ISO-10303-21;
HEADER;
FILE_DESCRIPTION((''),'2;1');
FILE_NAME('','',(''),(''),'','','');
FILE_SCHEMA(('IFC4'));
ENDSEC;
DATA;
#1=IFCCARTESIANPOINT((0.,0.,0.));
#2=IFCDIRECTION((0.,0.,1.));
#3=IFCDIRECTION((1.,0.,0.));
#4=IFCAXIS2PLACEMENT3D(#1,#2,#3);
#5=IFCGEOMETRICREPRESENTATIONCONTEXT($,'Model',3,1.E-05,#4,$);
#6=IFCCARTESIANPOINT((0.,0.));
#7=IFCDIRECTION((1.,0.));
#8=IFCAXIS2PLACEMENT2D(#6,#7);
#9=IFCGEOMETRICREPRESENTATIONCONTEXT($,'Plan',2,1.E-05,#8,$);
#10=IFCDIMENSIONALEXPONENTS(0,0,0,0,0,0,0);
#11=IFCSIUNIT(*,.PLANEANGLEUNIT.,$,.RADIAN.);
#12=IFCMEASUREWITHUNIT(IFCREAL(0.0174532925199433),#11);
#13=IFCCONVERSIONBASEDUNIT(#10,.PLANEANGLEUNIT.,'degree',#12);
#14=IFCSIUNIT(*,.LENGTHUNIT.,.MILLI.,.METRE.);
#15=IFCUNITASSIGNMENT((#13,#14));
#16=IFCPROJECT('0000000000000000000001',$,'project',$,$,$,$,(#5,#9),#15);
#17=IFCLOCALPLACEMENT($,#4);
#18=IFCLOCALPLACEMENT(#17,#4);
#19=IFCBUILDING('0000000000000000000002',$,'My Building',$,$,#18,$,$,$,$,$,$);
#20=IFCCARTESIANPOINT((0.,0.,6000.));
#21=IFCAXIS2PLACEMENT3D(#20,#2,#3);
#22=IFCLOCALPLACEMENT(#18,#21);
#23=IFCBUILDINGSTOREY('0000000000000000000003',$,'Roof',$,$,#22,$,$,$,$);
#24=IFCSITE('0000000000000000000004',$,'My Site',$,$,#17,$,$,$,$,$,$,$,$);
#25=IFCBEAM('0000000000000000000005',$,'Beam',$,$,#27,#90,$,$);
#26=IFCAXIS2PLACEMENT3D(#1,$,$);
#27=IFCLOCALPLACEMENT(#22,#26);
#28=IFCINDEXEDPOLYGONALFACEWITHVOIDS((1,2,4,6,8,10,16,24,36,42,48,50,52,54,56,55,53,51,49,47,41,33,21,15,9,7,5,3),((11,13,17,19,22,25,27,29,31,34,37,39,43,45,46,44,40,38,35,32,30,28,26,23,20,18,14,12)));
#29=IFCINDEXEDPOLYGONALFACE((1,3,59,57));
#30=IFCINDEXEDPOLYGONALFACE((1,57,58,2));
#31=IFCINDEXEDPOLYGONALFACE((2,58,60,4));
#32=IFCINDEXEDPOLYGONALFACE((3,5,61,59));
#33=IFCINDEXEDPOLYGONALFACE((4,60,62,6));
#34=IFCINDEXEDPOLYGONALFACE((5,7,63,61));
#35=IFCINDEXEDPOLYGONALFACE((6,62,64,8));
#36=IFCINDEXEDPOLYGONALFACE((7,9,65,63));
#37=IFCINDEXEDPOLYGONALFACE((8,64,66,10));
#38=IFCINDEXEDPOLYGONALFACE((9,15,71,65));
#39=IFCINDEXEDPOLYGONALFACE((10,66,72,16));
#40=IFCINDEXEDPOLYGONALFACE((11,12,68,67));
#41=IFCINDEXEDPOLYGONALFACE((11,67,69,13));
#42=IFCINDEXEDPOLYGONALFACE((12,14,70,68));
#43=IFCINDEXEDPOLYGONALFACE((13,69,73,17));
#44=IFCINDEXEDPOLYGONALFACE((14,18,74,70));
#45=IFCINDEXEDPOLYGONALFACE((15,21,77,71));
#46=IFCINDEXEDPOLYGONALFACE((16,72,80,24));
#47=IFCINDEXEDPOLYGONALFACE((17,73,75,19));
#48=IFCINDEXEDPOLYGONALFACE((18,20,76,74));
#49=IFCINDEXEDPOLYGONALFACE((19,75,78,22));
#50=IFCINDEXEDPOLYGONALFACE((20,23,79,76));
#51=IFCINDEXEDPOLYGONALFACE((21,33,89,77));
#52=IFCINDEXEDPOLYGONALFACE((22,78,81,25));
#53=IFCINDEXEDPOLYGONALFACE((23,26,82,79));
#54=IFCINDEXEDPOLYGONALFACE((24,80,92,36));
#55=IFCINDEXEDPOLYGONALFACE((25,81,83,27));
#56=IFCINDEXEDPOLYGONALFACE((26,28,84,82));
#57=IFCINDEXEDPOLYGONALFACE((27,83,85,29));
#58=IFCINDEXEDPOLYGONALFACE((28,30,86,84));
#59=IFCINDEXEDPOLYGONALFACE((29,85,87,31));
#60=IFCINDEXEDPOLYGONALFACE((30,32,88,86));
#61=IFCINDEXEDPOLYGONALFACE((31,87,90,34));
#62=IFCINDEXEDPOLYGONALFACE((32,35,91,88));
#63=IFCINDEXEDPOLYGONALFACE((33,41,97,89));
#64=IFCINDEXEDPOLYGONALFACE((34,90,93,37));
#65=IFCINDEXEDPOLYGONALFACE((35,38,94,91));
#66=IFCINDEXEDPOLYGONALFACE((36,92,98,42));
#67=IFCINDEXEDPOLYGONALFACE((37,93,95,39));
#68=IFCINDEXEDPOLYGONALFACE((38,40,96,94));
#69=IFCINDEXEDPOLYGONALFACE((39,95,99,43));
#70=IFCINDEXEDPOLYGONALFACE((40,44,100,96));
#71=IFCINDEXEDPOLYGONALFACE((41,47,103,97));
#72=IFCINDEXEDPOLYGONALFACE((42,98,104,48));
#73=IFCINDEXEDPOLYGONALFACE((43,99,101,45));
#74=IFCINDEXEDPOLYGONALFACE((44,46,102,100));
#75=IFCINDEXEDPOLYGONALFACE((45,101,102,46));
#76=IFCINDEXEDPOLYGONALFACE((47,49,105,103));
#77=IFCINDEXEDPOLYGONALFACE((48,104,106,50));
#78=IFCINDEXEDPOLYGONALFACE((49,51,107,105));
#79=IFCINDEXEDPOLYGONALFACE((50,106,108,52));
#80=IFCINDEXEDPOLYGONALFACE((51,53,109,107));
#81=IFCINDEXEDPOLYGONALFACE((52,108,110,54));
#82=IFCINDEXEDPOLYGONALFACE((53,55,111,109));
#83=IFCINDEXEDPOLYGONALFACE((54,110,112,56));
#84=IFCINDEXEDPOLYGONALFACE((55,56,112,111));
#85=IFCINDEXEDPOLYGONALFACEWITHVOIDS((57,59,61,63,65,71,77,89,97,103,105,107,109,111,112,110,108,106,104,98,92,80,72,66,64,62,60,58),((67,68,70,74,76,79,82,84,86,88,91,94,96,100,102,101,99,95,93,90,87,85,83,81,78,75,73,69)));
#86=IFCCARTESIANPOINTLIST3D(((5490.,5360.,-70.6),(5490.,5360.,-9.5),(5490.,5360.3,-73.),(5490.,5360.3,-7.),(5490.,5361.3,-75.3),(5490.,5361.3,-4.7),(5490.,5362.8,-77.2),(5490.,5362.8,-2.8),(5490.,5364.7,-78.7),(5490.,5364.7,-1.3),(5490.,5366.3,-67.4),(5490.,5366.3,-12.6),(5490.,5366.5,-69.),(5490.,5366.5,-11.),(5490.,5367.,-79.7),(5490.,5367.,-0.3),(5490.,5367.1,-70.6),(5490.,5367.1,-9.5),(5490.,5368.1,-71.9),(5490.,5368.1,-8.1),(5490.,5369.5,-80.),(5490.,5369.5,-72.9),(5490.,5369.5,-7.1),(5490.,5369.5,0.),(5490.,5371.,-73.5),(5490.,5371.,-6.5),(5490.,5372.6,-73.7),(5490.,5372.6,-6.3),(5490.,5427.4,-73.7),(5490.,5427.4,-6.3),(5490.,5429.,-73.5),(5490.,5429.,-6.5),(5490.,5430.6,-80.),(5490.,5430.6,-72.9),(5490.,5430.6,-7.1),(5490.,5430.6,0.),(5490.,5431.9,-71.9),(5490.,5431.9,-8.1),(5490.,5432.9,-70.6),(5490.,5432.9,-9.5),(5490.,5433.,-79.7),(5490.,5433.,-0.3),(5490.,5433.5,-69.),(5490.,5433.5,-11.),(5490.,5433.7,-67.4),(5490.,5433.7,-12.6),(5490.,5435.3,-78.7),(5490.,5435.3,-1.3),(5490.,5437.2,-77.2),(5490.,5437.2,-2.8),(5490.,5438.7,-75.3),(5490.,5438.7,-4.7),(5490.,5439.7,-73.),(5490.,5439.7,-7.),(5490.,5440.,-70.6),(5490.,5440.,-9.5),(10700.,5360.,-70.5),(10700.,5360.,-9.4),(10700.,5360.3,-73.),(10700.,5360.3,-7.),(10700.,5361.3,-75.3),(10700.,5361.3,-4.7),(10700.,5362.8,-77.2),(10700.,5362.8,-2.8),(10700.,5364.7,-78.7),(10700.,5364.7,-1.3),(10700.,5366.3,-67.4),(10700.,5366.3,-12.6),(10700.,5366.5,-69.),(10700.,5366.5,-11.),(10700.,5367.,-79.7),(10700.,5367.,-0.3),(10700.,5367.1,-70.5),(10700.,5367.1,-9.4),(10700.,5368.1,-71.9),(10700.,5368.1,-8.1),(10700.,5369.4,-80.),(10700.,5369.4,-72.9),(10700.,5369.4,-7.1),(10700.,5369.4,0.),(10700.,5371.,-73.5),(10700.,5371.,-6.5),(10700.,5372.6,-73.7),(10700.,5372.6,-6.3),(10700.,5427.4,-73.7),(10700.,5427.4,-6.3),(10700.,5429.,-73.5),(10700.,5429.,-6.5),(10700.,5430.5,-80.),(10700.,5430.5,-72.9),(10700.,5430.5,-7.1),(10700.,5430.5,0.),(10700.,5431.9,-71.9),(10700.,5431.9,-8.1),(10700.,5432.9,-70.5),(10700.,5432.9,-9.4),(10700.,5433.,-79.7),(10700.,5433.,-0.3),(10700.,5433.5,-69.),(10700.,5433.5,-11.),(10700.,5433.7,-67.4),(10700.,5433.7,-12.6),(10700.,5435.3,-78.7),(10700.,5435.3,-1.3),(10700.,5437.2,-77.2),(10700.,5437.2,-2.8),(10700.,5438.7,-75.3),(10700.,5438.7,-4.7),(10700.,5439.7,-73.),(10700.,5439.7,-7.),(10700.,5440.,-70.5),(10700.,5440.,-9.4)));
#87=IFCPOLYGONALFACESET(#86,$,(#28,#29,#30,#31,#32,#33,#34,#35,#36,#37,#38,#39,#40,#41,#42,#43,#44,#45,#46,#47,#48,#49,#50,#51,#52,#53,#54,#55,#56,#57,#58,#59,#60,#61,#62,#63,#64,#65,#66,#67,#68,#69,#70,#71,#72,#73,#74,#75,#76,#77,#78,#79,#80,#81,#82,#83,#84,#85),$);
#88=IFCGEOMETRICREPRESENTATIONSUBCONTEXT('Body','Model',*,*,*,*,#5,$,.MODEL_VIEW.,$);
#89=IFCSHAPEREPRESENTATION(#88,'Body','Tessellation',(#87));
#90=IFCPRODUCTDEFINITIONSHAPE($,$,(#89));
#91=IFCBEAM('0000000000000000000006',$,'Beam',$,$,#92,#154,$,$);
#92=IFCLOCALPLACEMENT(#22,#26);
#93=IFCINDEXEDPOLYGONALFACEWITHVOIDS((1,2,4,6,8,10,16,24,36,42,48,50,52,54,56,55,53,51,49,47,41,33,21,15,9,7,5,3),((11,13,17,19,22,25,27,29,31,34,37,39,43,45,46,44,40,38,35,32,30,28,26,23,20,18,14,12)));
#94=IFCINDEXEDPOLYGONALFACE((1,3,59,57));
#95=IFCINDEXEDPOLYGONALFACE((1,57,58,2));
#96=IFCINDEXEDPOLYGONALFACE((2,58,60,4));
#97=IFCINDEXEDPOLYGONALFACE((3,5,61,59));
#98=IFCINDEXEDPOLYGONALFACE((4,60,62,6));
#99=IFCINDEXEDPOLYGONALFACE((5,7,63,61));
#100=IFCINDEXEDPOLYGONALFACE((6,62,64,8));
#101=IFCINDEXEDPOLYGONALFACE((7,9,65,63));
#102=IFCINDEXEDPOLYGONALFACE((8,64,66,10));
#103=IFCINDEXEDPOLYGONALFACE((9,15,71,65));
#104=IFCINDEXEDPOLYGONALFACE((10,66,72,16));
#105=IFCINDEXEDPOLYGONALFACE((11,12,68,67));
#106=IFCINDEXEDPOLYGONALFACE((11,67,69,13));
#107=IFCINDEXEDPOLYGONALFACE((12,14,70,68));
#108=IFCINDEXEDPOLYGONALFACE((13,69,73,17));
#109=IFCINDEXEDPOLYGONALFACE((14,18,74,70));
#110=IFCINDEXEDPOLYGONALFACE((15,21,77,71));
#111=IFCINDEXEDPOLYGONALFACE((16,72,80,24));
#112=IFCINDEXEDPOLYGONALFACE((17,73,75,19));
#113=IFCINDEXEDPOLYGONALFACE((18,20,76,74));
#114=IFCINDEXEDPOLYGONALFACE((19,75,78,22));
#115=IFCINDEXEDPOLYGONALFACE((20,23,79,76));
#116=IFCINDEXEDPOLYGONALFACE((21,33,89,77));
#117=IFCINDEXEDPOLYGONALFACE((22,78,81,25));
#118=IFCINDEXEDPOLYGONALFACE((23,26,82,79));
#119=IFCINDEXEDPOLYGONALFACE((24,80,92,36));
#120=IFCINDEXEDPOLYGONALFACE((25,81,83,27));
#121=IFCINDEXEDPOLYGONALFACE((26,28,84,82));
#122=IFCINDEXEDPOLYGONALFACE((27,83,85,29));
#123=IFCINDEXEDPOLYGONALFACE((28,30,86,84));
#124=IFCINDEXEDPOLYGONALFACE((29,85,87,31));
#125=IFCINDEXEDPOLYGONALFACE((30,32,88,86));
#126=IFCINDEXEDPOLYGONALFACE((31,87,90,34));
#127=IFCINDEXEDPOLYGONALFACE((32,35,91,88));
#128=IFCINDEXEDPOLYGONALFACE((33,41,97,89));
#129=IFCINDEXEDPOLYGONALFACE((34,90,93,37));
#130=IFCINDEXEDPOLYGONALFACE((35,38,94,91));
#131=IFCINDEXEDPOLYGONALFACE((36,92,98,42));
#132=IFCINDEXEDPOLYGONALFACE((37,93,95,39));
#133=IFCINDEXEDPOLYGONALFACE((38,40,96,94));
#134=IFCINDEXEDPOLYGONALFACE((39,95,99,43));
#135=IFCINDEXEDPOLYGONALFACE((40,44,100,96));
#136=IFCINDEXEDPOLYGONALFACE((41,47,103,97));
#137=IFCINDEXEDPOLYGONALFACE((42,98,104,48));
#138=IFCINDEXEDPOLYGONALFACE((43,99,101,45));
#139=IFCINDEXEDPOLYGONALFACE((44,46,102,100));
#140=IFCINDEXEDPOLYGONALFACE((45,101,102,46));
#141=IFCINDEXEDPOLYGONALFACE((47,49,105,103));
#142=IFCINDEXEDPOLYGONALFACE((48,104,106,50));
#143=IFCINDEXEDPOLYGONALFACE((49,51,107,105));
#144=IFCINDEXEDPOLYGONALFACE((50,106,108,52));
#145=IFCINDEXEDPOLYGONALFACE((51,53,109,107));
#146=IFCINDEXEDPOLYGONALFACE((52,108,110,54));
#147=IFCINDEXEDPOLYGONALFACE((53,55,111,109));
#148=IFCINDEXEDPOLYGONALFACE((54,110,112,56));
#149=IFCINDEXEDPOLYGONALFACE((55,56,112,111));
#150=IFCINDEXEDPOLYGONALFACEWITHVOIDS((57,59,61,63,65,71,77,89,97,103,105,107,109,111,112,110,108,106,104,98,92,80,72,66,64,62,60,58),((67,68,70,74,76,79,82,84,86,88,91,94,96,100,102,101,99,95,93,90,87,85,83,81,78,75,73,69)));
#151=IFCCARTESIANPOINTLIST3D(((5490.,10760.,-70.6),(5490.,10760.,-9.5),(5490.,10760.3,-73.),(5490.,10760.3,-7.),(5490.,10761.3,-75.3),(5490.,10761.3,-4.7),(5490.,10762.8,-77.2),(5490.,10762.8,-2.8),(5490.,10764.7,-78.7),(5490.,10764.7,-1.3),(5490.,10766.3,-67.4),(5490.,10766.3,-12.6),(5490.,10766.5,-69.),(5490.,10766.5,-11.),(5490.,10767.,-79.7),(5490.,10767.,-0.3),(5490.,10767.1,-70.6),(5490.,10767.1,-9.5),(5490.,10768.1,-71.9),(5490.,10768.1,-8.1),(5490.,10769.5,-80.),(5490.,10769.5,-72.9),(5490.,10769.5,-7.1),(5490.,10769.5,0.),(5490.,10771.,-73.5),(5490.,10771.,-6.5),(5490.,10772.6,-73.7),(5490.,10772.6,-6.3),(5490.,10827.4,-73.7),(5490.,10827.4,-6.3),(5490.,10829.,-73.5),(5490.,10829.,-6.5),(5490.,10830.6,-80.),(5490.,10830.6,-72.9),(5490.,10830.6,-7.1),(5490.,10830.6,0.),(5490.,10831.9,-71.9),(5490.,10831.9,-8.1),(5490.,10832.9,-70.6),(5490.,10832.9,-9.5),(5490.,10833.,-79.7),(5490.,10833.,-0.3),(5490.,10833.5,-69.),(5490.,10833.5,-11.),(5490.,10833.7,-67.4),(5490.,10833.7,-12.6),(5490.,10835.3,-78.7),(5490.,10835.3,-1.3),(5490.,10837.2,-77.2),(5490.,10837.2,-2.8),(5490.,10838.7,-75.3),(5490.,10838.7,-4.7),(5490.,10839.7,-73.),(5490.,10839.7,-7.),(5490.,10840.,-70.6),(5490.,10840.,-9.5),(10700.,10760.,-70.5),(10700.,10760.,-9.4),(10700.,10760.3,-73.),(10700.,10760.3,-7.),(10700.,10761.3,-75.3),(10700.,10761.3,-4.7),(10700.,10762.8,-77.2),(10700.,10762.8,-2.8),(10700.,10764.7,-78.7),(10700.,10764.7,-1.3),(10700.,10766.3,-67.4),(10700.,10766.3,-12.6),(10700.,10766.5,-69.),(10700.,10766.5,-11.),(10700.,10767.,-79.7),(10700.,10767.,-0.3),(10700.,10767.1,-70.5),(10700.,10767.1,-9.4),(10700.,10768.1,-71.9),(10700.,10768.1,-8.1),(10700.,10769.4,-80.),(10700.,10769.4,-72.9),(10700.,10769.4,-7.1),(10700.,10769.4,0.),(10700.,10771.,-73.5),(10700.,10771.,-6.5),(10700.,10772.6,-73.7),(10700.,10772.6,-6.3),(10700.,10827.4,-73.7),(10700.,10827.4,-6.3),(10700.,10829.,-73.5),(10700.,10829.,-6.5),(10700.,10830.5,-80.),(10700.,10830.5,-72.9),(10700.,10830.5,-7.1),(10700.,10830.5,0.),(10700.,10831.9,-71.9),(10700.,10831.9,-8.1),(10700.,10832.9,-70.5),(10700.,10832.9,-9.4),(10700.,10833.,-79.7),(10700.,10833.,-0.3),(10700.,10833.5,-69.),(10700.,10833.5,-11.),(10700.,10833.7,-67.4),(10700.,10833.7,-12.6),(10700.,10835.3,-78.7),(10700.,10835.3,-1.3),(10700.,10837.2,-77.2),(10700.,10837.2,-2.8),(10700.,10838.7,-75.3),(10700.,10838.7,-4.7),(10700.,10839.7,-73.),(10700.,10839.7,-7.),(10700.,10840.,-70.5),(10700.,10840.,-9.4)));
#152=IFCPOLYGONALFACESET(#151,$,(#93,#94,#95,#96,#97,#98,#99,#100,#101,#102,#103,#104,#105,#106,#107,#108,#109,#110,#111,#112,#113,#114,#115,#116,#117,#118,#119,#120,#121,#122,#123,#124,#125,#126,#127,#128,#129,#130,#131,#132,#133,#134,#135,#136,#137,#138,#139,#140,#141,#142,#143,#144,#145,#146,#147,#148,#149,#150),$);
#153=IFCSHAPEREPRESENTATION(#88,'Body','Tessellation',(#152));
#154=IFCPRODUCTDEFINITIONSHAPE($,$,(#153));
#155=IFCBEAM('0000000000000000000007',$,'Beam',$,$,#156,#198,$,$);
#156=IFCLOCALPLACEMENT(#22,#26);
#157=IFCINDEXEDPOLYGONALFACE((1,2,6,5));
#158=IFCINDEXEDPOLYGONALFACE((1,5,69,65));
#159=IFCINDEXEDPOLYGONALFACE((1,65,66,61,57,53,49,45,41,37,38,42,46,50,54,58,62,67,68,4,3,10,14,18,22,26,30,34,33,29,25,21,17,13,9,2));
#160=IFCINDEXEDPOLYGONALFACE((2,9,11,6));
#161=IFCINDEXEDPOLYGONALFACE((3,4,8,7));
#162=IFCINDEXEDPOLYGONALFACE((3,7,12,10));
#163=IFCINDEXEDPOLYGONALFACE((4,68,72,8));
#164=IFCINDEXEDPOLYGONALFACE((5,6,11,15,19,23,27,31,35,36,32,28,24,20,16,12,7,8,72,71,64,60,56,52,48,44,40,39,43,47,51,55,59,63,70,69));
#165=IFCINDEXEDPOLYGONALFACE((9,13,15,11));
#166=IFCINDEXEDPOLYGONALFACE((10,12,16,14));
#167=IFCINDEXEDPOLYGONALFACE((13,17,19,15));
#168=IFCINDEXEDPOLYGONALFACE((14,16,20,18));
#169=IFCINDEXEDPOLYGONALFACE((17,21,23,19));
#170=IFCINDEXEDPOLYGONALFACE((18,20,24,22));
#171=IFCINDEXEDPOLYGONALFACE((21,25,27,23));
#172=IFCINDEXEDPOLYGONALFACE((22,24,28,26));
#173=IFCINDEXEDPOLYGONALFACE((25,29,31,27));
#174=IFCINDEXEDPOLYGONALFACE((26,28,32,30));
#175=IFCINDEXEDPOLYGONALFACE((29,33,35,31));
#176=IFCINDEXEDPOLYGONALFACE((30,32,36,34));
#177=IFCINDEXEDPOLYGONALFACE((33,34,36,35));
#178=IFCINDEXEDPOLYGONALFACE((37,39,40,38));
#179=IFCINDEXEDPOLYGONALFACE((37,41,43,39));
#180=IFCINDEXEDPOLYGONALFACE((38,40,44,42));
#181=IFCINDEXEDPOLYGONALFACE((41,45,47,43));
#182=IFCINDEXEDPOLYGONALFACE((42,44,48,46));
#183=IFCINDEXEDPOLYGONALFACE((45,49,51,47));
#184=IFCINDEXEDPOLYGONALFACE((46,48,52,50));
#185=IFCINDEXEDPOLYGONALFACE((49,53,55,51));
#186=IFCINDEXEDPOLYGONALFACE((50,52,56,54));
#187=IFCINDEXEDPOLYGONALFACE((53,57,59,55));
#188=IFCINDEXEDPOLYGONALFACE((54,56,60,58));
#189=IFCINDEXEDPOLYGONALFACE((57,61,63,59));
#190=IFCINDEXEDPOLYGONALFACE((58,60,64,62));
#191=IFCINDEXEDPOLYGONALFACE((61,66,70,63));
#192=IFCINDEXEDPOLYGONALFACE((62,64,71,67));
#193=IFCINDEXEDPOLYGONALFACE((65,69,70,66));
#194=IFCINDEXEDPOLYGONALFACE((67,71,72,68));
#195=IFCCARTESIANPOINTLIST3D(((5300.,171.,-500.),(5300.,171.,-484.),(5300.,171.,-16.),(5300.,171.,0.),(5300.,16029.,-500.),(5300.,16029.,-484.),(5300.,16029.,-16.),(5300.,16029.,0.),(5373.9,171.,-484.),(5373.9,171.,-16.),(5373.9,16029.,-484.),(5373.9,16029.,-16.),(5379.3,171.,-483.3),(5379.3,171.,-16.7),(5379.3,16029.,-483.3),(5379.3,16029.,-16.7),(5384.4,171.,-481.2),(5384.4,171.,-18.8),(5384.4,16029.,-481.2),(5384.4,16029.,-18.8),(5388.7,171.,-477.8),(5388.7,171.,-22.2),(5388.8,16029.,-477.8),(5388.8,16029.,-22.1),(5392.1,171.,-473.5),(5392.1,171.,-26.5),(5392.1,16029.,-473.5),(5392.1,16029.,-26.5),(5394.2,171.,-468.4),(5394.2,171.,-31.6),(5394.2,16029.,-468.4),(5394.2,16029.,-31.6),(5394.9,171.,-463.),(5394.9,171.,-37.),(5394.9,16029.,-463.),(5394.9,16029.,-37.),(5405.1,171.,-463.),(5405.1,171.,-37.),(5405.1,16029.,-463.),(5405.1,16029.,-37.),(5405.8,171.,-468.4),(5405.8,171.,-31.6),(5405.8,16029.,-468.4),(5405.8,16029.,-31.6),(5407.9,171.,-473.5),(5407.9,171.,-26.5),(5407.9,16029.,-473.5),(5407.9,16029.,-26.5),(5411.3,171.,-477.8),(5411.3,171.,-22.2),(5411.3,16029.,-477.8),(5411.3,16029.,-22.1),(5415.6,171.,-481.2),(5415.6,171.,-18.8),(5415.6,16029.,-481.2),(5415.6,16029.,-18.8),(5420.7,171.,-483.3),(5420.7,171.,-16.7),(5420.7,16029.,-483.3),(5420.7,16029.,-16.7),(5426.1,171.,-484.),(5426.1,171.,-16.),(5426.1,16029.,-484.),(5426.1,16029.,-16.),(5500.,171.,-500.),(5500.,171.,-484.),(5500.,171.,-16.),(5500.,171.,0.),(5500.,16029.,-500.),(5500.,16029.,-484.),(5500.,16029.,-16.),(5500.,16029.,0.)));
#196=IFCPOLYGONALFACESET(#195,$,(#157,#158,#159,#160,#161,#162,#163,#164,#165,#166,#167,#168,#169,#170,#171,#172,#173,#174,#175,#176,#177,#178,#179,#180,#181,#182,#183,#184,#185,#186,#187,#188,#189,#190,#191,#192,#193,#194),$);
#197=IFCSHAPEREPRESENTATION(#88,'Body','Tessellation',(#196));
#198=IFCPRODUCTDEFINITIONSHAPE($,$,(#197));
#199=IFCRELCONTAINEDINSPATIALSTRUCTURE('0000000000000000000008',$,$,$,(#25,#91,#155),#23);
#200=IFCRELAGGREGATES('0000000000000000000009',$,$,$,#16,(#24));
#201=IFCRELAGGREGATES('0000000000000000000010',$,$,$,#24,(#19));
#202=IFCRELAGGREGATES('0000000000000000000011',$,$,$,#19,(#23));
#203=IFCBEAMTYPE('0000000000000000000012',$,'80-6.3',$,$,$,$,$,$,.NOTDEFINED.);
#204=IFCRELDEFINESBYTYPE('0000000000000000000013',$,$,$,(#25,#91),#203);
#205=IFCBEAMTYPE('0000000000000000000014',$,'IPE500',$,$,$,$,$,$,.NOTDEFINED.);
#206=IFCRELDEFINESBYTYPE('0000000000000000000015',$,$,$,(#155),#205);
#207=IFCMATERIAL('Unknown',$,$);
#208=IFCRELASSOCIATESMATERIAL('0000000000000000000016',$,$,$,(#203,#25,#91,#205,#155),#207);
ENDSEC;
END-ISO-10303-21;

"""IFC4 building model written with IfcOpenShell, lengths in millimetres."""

from ifc_helpers import new_model, entity, si_unit, converted_unit, frame, origin_with_axes, origin_2d_with_axis, place, context, subcontext, project, spatial, hollow_rectangle, i_section, extrude, material, material_profile, profile_set, profile_usage, type_object, element, save


model = new_model("IFC4")

# Units and contexts
model_context = context("Model", 3, precision=1e-05, world=origin_with_axes())
plan_context = context("Plan", 2, precision=1e-05, world=origin_2d_with_axis())
body_context = subcontext(model_context, "Body", "Model", "MODEL_VIEW")
ifc_project = project(units=[converted_unit("PLANEANGLEUNIT", "degree", entity("IfcReal", 0.0174532925199433), si_unit("PLANEANGLEUNIT", "RADIAN"), dimensions=[0, 0, 0, 0, 0, 0, 0]), si_unit("LENGTHUNIT", "METRE", prefix="MILLI")], contexts=[model_context, plan_context])

# Site, building, storey
site_placement = place(None, origin_with_axes())
site = spatial("IfcSite", under=ifc_project, at=site_placement, Name="My Site")
building_placement = place(site_placement, origin_with_axes())
building = spatial("IfcBuilding", under=site, at=building_placement, Name="My Building")
storey_placement = place(building_placement, frame((0.0, 0.0, 6000.0), z_axis=(0.0, 0.0, 1.0), x_axis=(1.0, 0.0, 0.0)))
storey = spatial("IfcBuildingStorey", under=building, at=storey_placement, Name="Roof")

# Beams
ifc_material = material(Name="Unknown")
ifc_material_profile_1 = material_profile(ifc_material, hollow_rectangle(XDim=80.0, YDim=80.0, WallThickness=6.3, InnerFilletRadius=6.3, OuterFilletRadius=9.4))
ifc_profile_set_1 = profile_set([ifc_material_profile_1])
beam_type_1 = type_object("IfcBeamType", Name="80-6.3", PredefinedType="NOTDEFINED", material=ifc_profile_set_1)
ifc_profile_usage_1 = profile_usage(ifc_profile_set_1, cardinal=8)
beam_1_placement = place(storey_placement, frame((5490.0, 5400.0, 0.0), z_axis=(1.0, 0.0, 0.0), x_axis=(0.0, 1.0, 0.0)))
element("IfcBeam", 1, at=beam_1_placement, inside=storey, type_object=beam_type_1, material=ifc_profile_usage_1, Name="Beam", context=body_context, shape_type="SweptSolid", body=[
    extrude(hollow_rectangle(XDim=80.0, YDim=80.0, WallThickness=6.3, InnerFilletRadius=6.3, OuterFilletRadius=9.4), frame((0.0, -40.0, 0.0), z_axis=(0.0, 0.0, 1.0), x_axis=(1.0, 0.0, 0.0)), (0.0, 0.0, 1.0), 5210.0),
])
ifc_profile_usage_2 = profile_usage(ifc_profile_set_1, cardinal=8)
beam_2_placement = place(storey_placement, frame((5490.0, 10800.0, 0.0), z_axis=(1.0, 0.0, 0.0), x_axis=(0.0, 1.0, 0.0)))
element("IfcBeam", 2, at=beam_2_placement, inside=storey, type_object=beam_type_1, material=ifc_profile_usage_2, Name="Beam", context=body_context, shape_type="SweptSolid", body=[
    extrude(hollow_rectangle(XDim=80.0, YDim=80.0, WallThickness=6.3, InnerFilletRadius=6.3, OuterFilletRadius=9.4), frame((0.0, -40.0, 0.0), z_axis=(0.0, 0.0, 1.0), x_axis=(1.0, 0.0, 0.0)), (0.0, 0.0, 1.0), 5210.0),
])
ifc_material_profile_2 = material_profile(ifc_material, i_section(OverallWidth=200.0, OverallDepth=500.0, WebThickness=10.2, FlangeThickness=16.0, FilletRadius=21.0))
ifc_profile_set_2 = profile_set([ifc_material_profile_2])
ifc_profile_usage_3 = profile_usage(ifc_profile_set_2, cardinal=8)
beam_type_2 = type_object("IfcBeamType", Name="IPE500", PredefinedType="NOTDEFINED", material=ifc_profile_set_2)
beam_3_placement = place(storey_placement, frame((5400.0, 171.0, 0.0), z_axis=(0.0, 1.0, 0.0), x_axis=(-1.0, 0.0, 0.0)))
element("IfcBeam", 3, at=beam_3_placement, inside=storey, type_object=beam_type_2, material=ifc_profile_usage_3, Name="Beam", context=body_context, shape_type="SweptSolid", body=[
    extrude(i_section(OverallWidth=200.0, OverallDepth=500.0, WebThickness=10.2, FlangeThickness=16.0, FilletRadius=21.0), frame((0.0, -250.0, 0.0), z_axis=(0.0, 0.0, 1.0), x_axis=(1.0, 0.0, 0.0)), (0.0, 0.0, 1.0), 15858.0),
])

save(model, "model.ifc")
